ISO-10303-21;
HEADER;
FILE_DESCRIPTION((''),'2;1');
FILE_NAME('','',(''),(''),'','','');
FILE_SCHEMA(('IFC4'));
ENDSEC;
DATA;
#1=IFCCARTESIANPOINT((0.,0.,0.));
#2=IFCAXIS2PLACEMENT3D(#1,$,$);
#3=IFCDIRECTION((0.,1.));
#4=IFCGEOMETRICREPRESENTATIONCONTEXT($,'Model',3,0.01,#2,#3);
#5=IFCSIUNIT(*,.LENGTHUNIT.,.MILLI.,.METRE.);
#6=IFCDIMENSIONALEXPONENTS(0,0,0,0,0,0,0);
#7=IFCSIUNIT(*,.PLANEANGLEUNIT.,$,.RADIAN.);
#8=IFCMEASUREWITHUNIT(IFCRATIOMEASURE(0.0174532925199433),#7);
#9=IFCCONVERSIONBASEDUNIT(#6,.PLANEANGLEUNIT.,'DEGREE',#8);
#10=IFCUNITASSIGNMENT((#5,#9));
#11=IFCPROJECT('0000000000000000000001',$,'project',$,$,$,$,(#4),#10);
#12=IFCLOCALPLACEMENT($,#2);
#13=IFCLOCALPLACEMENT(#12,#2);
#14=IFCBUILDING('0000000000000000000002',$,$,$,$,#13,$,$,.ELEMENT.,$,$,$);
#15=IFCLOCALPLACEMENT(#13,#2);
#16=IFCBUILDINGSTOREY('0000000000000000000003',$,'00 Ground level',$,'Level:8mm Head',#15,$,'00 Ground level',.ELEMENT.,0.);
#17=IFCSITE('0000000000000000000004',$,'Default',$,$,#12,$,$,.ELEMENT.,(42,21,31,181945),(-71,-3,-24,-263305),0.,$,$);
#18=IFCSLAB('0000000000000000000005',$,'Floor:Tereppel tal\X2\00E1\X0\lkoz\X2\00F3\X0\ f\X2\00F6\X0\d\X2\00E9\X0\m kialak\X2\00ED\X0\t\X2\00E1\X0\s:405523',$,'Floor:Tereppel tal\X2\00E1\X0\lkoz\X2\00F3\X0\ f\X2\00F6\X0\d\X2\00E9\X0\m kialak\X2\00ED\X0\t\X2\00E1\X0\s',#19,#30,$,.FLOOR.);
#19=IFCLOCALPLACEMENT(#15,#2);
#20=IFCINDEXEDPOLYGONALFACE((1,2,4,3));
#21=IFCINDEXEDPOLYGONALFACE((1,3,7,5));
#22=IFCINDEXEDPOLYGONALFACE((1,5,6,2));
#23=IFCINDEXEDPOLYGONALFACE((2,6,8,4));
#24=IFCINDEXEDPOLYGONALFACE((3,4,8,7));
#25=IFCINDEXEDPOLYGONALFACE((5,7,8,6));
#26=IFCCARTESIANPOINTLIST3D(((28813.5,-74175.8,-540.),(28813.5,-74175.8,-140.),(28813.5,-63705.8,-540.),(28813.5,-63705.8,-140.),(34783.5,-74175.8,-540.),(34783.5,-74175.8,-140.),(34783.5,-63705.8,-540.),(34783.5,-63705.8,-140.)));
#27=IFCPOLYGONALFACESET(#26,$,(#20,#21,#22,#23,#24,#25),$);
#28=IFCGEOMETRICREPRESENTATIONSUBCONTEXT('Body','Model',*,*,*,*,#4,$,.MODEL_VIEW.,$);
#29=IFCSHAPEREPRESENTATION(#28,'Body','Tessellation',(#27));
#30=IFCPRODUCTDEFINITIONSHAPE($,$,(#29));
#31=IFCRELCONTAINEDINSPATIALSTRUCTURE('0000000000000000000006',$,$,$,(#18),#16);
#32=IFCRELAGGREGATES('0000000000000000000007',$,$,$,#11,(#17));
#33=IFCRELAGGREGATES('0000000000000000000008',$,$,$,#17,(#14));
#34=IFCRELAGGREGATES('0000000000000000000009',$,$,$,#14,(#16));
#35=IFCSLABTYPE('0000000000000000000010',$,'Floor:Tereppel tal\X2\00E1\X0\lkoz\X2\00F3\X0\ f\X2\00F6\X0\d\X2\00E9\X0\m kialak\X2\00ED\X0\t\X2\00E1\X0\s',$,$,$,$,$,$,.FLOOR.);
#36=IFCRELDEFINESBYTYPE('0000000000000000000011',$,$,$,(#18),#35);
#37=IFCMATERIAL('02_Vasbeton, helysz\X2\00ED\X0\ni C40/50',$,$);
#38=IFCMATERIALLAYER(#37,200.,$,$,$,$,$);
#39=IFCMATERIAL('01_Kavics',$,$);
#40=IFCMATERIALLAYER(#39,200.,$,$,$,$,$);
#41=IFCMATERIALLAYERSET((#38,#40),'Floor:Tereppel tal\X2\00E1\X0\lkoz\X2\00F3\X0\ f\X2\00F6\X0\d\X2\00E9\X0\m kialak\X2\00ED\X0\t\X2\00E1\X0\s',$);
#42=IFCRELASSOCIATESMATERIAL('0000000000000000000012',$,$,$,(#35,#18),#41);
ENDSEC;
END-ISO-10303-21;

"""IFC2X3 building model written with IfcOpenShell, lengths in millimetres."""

from ifc_helpers import new_model, entity, si_unit, converted_unit, direction, frame, origin, origin_2d_with_axis, place, context, subcontext, project, spatial, rectangle, extrude, material, layer, layer_set, layer_usage, type_object, element, save


model = new_model("IFC2X3")

# Units and contexts
model_context = context("Model", 3, precision=0.01, world=origin(), true_north=direction((0.0, 1.0)))
body_context = subcontext(model_context, "Body", "Model", "MODEL_VIEW")
ifc_project = project(units=[si_unit("LENGTHUNIT", "METRE", prefix="MILLI"), converted_unit("PLANEANGLEUNIT", "DEGREE", entity("IfcRatioMeasure", 0.0174532925199433), si_unit("PLANEANGLEUNIT", "RADIAN"), dimensions=[0, 0, 0, 0, 0, 0, 0])], contexts=[model_context])

# Site, building, storey
site_placement = place(None, origin())
site = spatial("IfcSite", under=ifc_project, at=site_placement, Name="Default", CompositionType="ELEMENT", RefLatitude=(42, 21, 31, 181945), RefLongitude=(-71, -3, -24, -263305), RefElevation=0.0)
building_placement = place(site_placement, origin())
building = spatial("IfcBuilding", under=site, at=building_placement, CompositionType="ELEMENT")
storey_placement = place(building_placement, origin())
storey = spatial("IfcBuildingStorey", under=building, at=storey_placement, Name="00 Ground level", ObjectType="Level:8mm Head", LongName="00 Ground level", CompositionType="ELEMENT", Elevation=0.0)

# Slab
ifc_material_1 = material(Name="02_Vasbeton, helyszíni C40/50")
ifc_layer_1 = layer(ifc_material_1, 200.0)
ifc_material_2 = material(Name="01_Kavics")
ifc_layer_2 = layer(ifc_material_2, 200.0)
ifc_layer_set = layer_set([ifc_layer_1, ifc_layer_2], Name="Floor:Tereppel találkozó födém kialakítás")
ifc_layer_usage_1 = layer_usage(ifc_layer_set, "AXIS3", "POSITIVE", 0.0)
slab_type_1 = type_object("IfcSlabType", Name="Floor:Tereppel találkozó födém kialakítás", PredefinedType="FLOOR", material=ifc_layer_set)
slab_1_placement = place(storey_placement, origin())
element("IfcSlab", 1, at=slab_1_placement, inside=storey, type_object=slab_type_1, material=ifc_layer_usage_1, Name="Floor:Tereppel találkozó födém kialakítás:405523", ObjectType="Floor:Tereppel találkozó födém kialakítás", PredefinedType="FLOOR", context=body_context, shape_type="SweptSolid", body=[
    extrude(rectangle(XDim=10470.0, YDim=5970.0, at=origin_2d_with_axis()), frame((31798.5, -68940.8, -140.0), z_axis=(0.0, 0.0, -1.0), x_axis=(0.0, 1.0, 0.0)), (0.0, 0.0, 1.0), 400.0),
])

save(model, "model.ifc")
